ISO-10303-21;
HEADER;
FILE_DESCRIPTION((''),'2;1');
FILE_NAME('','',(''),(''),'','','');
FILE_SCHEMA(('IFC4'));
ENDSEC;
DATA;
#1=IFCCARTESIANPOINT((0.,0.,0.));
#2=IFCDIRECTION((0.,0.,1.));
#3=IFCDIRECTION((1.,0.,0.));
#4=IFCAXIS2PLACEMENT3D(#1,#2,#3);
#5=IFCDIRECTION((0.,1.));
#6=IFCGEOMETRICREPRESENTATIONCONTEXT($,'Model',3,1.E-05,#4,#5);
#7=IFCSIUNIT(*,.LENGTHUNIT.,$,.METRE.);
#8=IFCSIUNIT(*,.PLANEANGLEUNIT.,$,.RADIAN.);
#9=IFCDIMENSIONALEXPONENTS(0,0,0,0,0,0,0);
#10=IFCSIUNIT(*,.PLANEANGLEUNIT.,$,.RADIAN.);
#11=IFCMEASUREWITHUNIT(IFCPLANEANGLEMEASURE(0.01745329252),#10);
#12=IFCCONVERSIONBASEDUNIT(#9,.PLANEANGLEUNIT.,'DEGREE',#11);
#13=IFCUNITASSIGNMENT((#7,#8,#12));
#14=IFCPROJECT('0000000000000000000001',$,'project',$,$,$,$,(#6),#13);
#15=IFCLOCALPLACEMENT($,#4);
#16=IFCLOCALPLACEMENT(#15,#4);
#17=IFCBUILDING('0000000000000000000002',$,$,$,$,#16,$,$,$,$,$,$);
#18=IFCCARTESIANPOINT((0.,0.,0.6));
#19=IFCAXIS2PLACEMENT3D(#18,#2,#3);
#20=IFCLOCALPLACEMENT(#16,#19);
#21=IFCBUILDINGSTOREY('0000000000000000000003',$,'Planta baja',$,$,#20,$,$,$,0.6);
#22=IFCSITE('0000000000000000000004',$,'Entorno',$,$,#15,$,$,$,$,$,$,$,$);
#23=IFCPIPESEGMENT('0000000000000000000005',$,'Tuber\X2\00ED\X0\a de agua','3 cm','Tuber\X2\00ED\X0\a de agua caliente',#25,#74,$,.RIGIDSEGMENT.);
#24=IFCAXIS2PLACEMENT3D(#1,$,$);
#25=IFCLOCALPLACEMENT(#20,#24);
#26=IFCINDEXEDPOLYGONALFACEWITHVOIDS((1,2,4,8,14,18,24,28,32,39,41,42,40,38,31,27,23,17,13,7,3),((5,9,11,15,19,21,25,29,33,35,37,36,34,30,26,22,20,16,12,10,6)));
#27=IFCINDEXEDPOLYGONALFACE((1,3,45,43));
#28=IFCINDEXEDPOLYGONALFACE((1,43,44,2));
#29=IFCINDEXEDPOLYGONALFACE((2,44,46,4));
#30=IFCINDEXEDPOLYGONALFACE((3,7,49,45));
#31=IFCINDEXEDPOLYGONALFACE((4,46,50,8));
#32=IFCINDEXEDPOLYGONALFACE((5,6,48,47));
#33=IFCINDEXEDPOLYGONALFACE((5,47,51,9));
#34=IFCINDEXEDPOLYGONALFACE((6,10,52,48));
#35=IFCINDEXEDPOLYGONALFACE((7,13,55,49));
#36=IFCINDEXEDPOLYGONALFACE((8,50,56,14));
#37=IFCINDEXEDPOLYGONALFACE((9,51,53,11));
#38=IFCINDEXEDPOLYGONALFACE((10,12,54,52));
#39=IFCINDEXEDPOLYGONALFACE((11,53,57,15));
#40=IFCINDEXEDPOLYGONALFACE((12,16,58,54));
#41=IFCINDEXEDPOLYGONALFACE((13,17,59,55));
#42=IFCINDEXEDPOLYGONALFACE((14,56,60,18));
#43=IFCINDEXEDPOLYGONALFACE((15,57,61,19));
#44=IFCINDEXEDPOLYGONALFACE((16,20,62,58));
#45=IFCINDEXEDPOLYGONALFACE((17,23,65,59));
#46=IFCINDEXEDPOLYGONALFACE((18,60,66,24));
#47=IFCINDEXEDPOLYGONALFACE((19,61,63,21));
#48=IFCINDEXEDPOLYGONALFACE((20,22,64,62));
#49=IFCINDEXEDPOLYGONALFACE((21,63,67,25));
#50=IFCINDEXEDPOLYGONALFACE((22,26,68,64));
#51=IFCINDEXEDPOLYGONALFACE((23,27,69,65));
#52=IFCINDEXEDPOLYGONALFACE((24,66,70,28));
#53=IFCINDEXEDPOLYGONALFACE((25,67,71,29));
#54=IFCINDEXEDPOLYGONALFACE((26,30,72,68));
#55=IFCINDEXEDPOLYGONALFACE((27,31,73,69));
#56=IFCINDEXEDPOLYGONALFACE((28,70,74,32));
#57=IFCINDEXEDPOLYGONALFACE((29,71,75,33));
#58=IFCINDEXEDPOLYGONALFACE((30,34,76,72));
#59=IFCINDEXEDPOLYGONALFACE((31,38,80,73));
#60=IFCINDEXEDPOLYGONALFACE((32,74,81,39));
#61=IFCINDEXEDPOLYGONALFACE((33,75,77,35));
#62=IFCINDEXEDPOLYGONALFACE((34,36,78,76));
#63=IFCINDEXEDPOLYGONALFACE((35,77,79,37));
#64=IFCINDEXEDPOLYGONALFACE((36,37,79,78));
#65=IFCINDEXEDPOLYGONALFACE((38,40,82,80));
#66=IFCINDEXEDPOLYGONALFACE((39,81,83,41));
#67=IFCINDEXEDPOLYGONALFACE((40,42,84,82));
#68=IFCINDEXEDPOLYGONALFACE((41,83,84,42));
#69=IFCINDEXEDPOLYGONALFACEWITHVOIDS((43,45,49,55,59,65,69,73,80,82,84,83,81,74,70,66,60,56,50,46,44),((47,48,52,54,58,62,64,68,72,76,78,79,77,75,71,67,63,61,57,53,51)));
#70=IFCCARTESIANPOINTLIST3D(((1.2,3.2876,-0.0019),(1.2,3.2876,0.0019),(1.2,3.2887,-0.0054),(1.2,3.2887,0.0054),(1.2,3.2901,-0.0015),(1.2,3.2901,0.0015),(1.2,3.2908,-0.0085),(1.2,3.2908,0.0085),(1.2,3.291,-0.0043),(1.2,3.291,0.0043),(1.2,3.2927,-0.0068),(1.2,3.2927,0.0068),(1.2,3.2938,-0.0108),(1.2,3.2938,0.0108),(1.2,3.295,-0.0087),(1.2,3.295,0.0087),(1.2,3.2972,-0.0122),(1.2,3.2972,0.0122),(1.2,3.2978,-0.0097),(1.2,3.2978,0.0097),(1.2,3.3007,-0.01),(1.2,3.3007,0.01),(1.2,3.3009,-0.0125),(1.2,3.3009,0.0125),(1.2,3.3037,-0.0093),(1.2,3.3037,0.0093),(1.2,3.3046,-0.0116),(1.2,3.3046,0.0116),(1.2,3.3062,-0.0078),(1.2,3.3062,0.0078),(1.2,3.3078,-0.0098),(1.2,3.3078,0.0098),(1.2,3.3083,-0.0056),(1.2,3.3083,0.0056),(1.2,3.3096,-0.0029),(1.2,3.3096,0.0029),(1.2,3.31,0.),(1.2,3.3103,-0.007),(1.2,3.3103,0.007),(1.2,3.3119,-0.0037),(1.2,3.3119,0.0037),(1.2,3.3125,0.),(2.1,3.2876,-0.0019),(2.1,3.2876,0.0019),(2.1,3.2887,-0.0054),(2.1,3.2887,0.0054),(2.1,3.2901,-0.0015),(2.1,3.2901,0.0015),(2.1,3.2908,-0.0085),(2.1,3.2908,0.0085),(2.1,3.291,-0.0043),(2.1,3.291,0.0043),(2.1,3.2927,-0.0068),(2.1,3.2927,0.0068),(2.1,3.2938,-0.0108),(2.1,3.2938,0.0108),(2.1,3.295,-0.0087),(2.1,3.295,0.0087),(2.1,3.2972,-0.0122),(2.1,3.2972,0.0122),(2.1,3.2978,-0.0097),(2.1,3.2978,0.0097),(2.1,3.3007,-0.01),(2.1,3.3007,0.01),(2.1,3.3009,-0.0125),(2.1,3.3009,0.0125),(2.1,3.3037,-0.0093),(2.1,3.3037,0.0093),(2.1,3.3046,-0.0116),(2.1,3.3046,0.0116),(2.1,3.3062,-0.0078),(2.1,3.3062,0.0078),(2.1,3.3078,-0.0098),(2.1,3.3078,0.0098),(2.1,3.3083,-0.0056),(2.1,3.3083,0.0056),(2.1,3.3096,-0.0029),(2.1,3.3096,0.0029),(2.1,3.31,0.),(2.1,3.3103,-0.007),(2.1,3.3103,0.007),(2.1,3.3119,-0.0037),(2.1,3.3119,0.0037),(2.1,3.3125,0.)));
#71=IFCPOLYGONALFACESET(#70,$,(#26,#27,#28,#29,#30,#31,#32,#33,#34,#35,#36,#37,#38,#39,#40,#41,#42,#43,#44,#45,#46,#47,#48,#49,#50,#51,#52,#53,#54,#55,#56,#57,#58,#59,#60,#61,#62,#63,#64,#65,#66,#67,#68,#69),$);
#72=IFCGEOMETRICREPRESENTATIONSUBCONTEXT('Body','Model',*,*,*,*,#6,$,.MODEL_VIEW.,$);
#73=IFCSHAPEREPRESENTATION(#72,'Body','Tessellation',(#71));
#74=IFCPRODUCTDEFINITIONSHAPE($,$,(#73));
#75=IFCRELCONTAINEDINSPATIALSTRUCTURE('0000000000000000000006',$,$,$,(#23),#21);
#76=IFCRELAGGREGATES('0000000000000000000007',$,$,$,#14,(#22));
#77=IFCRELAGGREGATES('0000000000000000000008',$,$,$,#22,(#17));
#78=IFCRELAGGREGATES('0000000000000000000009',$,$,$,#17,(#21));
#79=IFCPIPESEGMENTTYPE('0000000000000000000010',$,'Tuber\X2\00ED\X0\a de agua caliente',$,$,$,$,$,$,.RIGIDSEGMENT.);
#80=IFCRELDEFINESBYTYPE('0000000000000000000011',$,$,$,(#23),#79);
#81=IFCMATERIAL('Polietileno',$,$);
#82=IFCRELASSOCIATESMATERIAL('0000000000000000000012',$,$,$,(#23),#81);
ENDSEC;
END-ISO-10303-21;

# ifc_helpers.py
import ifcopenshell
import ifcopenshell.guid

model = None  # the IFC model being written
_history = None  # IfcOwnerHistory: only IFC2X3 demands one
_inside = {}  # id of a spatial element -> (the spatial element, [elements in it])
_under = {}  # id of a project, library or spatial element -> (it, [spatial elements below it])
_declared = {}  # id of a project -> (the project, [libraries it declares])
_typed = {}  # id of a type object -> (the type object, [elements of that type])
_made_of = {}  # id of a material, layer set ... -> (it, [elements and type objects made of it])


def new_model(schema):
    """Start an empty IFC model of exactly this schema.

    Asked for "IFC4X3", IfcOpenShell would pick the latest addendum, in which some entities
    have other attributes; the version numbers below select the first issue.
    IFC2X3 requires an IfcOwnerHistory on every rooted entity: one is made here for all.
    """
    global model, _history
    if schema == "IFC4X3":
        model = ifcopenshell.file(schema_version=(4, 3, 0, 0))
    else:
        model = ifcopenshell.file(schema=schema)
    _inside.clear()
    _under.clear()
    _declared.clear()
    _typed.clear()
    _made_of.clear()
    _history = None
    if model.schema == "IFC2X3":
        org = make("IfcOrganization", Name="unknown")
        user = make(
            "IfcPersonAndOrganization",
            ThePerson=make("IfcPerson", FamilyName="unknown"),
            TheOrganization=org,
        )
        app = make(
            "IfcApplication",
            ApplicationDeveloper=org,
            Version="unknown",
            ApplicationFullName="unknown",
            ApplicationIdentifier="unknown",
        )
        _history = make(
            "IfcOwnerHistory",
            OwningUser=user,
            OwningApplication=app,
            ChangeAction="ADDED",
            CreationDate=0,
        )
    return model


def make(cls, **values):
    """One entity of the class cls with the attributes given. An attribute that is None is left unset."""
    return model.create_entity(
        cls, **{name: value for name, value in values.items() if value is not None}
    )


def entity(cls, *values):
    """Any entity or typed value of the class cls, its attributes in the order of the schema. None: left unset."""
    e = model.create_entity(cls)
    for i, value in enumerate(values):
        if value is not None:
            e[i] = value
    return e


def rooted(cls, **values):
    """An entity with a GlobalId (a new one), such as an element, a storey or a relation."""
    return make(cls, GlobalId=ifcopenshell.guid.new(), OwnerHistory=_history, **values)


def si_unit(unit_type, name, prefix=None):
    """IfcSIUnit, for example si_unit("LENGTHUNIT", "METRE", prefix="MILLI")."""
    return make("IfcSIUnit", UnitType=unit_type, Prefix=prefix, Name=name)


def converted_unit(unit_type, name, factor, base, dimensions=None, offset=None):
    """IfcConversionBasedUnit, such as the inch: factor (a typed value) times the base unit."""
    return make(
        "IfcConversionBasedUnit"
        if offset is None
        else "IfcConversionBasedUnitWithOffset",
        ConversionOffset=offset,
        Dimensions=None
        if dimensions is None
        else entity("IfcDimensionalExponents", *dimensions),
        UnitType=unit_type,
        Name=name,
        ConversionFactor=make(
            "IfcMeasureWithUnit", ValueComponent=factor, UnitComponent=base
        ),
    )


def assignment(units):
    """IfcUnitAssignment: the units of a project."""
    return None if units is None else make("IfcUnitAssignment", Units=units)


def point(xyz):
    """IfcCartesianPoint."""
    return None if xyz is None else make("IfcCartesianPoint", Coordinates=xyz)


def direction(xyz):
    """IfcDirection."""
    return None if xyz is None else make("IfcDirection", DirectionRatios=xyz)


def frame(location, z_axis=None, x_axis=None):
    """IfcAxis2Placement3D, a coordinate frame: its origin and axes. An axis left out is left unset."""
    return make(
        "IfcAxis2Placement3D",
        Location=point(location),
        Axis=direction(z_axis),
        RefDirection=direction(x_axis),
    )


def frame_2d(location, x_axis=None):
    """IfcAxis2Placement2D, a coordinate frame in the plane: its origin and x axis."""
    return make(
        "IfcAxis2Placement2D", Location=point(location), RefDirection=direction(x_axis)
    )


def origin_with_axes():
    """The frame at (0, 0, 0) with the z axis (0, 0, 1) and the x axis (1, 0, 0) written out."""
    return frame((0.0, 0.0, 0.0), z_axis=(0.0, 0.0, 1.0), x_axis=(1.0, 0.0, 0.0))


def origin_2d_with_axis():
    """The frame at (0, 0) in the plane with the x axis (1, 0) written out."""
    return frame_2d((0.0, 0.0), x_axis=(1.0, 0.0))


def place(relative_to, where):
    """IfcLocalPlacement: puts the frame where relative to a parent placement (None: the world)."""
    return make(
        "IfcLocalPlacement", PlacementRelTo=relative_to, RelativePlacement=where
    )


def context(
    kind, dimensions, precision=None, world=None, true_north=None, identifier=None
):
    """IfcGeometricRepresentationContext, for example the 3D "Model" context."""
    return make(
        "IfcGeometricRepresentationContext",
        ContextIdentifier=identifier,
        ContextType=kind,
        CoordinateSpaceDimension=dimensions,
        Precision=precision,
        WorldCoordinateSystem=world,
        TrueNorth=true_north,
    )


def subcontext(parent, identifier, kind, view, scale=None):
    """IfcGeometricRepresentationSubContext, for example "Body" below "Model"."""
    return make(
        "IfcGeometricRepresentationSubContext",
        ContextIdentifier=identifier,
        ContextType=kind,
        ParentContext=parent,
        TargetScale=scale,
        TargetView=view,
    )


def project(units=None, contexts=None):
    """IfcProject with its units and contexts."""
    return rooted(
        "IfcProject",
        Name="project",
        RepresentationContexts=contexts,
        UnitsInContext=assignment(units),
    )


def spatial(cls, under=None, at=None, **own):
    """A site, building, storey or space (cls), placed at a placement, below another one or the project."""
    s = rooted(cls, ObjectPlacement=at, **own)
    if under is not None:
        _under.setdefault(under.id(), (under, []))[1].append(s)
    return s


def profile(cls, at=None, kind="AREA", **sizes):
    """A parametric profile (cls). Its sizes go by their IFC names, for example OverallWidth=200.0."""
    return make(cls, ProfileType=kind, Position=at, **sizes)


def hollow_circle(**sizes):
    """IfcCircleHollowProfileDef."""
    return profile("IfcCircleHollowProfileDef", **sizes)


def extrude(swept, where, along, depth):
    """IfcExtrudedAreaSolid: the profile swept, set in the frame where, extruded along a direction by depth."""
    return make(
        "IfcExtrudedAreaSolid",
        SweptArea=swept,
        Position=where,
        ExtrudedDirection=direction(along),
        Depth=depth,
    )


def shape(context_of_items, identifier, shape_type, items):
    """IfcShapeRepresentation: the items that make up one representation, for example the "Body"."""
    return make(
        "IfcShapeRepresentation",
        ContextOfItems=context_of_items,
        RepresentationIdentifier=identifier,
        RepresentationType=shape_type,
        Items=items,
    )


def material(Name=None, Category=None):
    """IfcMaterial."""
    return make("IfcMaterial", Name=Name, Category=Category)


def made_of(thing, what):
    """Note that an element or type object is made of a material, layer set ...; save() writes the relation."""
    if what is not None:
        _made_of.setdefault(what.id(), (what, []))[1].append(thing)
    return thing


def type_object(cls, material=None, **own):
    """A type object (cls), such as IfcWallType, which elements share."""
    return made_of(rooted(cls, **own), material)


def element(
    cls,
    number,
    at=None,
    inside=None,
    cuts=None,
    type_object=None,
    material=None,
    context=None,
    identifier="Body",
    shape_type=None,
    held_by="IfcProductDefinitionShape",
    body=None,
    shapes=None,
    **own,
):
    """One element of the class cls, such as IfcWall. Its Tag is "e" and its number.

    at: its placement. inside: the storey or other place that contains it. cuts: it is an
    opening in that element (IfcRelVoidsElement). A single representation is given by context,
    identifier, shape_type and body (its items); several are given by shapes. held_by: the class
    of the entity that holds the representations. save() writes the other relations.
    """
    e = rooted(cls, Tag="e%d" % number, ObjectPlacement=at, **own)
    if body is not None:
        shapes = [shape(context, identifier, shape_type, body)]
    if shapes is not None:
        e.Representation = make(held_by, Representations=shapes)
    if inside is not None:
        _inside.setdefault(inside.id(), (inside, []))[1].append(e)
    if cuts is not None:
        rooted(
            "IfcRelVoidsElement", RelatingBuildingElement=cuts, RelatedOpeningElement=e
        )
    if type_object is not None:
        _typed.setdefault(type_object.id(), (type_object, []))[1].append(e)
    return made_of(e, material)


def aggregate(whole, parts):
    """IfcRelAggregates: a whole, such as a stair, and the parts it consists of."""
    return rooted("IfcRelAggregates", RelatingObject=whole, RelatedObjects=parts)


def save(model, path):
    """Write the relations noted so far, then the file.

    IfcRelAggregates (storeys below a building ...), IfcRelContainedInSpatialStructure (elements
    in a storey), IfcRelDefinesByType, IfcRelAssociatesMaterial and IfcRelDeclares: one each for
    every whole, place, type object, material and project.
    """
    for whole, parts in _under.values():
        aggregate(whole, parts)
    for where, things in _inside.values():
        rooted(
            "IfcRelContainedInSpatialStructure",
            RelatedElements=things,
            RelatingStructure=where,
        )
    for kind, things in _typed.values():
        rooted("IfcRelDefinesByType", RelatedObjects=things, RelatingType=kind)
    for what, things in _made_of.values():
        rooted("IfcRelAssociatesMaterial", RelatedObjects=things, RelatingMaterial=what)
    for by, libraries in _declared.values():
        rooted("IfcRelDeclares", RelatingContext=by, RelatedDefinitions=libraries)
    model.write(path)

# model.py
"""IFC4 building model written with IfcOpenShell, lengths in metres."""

from ifc_helpers import new_model, entity, si_unit, converted_unit, direction, frame, origin_with_axes, origin_2d_with_axis, place, context, subcontext, project, spatial, hollow_circle, extrude, material, type_object, element, save


model = new_model("IFC4")

# Units and contexts
model_context = context("Model", 3, precision=1e-05, world=origin_with_axes(), true_north=direction((0.0, 1.0)))
body_context = subcontext(model_context, "Body", "Model", "MODEL_VIEW")
ifc_project = project(units=[si_unit("LENGTHUNIT", "METRE"), si_unit("PLANEANGLEUNIT", "RADIAN"), converted_unit("PLANEANGLEUNIT", "DEGREE", entity("IfcPlaneAngleMeasure", 0.01745329252), si_unit("PLANEANGLEUNIT", "RADIAN"), dimensions=[0, 0, 0, 0, 0, 0, 0])], contexts=[model_context])

# Site, building, storey
site_placement = place(None, origin_with_axes())
site = spatial("IfcSite", under=ifc_project, at=site_placement, Name="Entorno")
building_placement = place(site_placement, origin_with_axes())
building = spatial("IfcBuilding", under=site, at=building_placement)
storey_placement = place(building_placement, frame((0.0, 0.0, 0.6), z_axis=(0.0, 0.0, 1.0), x_axis=(1.0, 0.0, 0.0)))
storey = spatial("IfcBuildingStorey", under=building, at=storey_placement, Name="Planta baja", Elevation=0.6)

# Shared definitions
ifc_material_1 = material(Name="Polietileno")

# Pipe segment
pipe_segment_type_1 = type_object("IfcPipeSegmentType", Name="Tubería de agua caliente", PredefinedType="RIGIDSEGMENT")
pipe_segment_1_placement = place(storey_placement, frame((1.2, 3.3, 0.0), z_axis=(1.0, 0.0, 0.0), x_axis=(0.0, 1.0, 0.0)))
element("IfcPipeSegment", 1, at=pipe_segment_1_placement, inside=storey, type_object=pipe_segment_type_1, material=ifc_material_1, Name="Tubería de agua", Description="3 cm", ObjectType="Tubería de agua caliente", PredefinedType="RIGIDSEGMENT", context=body_context, shape_type="SweptSolid", body=[
    extrude(hollow_circle(Radius=0.0125, WallThickness=0.0025, at=origin_2d_with_axis()), origin_with_axes(), (0.0, 0.0, 1.0), 0.9),
])

save(model, "model.ifc")
